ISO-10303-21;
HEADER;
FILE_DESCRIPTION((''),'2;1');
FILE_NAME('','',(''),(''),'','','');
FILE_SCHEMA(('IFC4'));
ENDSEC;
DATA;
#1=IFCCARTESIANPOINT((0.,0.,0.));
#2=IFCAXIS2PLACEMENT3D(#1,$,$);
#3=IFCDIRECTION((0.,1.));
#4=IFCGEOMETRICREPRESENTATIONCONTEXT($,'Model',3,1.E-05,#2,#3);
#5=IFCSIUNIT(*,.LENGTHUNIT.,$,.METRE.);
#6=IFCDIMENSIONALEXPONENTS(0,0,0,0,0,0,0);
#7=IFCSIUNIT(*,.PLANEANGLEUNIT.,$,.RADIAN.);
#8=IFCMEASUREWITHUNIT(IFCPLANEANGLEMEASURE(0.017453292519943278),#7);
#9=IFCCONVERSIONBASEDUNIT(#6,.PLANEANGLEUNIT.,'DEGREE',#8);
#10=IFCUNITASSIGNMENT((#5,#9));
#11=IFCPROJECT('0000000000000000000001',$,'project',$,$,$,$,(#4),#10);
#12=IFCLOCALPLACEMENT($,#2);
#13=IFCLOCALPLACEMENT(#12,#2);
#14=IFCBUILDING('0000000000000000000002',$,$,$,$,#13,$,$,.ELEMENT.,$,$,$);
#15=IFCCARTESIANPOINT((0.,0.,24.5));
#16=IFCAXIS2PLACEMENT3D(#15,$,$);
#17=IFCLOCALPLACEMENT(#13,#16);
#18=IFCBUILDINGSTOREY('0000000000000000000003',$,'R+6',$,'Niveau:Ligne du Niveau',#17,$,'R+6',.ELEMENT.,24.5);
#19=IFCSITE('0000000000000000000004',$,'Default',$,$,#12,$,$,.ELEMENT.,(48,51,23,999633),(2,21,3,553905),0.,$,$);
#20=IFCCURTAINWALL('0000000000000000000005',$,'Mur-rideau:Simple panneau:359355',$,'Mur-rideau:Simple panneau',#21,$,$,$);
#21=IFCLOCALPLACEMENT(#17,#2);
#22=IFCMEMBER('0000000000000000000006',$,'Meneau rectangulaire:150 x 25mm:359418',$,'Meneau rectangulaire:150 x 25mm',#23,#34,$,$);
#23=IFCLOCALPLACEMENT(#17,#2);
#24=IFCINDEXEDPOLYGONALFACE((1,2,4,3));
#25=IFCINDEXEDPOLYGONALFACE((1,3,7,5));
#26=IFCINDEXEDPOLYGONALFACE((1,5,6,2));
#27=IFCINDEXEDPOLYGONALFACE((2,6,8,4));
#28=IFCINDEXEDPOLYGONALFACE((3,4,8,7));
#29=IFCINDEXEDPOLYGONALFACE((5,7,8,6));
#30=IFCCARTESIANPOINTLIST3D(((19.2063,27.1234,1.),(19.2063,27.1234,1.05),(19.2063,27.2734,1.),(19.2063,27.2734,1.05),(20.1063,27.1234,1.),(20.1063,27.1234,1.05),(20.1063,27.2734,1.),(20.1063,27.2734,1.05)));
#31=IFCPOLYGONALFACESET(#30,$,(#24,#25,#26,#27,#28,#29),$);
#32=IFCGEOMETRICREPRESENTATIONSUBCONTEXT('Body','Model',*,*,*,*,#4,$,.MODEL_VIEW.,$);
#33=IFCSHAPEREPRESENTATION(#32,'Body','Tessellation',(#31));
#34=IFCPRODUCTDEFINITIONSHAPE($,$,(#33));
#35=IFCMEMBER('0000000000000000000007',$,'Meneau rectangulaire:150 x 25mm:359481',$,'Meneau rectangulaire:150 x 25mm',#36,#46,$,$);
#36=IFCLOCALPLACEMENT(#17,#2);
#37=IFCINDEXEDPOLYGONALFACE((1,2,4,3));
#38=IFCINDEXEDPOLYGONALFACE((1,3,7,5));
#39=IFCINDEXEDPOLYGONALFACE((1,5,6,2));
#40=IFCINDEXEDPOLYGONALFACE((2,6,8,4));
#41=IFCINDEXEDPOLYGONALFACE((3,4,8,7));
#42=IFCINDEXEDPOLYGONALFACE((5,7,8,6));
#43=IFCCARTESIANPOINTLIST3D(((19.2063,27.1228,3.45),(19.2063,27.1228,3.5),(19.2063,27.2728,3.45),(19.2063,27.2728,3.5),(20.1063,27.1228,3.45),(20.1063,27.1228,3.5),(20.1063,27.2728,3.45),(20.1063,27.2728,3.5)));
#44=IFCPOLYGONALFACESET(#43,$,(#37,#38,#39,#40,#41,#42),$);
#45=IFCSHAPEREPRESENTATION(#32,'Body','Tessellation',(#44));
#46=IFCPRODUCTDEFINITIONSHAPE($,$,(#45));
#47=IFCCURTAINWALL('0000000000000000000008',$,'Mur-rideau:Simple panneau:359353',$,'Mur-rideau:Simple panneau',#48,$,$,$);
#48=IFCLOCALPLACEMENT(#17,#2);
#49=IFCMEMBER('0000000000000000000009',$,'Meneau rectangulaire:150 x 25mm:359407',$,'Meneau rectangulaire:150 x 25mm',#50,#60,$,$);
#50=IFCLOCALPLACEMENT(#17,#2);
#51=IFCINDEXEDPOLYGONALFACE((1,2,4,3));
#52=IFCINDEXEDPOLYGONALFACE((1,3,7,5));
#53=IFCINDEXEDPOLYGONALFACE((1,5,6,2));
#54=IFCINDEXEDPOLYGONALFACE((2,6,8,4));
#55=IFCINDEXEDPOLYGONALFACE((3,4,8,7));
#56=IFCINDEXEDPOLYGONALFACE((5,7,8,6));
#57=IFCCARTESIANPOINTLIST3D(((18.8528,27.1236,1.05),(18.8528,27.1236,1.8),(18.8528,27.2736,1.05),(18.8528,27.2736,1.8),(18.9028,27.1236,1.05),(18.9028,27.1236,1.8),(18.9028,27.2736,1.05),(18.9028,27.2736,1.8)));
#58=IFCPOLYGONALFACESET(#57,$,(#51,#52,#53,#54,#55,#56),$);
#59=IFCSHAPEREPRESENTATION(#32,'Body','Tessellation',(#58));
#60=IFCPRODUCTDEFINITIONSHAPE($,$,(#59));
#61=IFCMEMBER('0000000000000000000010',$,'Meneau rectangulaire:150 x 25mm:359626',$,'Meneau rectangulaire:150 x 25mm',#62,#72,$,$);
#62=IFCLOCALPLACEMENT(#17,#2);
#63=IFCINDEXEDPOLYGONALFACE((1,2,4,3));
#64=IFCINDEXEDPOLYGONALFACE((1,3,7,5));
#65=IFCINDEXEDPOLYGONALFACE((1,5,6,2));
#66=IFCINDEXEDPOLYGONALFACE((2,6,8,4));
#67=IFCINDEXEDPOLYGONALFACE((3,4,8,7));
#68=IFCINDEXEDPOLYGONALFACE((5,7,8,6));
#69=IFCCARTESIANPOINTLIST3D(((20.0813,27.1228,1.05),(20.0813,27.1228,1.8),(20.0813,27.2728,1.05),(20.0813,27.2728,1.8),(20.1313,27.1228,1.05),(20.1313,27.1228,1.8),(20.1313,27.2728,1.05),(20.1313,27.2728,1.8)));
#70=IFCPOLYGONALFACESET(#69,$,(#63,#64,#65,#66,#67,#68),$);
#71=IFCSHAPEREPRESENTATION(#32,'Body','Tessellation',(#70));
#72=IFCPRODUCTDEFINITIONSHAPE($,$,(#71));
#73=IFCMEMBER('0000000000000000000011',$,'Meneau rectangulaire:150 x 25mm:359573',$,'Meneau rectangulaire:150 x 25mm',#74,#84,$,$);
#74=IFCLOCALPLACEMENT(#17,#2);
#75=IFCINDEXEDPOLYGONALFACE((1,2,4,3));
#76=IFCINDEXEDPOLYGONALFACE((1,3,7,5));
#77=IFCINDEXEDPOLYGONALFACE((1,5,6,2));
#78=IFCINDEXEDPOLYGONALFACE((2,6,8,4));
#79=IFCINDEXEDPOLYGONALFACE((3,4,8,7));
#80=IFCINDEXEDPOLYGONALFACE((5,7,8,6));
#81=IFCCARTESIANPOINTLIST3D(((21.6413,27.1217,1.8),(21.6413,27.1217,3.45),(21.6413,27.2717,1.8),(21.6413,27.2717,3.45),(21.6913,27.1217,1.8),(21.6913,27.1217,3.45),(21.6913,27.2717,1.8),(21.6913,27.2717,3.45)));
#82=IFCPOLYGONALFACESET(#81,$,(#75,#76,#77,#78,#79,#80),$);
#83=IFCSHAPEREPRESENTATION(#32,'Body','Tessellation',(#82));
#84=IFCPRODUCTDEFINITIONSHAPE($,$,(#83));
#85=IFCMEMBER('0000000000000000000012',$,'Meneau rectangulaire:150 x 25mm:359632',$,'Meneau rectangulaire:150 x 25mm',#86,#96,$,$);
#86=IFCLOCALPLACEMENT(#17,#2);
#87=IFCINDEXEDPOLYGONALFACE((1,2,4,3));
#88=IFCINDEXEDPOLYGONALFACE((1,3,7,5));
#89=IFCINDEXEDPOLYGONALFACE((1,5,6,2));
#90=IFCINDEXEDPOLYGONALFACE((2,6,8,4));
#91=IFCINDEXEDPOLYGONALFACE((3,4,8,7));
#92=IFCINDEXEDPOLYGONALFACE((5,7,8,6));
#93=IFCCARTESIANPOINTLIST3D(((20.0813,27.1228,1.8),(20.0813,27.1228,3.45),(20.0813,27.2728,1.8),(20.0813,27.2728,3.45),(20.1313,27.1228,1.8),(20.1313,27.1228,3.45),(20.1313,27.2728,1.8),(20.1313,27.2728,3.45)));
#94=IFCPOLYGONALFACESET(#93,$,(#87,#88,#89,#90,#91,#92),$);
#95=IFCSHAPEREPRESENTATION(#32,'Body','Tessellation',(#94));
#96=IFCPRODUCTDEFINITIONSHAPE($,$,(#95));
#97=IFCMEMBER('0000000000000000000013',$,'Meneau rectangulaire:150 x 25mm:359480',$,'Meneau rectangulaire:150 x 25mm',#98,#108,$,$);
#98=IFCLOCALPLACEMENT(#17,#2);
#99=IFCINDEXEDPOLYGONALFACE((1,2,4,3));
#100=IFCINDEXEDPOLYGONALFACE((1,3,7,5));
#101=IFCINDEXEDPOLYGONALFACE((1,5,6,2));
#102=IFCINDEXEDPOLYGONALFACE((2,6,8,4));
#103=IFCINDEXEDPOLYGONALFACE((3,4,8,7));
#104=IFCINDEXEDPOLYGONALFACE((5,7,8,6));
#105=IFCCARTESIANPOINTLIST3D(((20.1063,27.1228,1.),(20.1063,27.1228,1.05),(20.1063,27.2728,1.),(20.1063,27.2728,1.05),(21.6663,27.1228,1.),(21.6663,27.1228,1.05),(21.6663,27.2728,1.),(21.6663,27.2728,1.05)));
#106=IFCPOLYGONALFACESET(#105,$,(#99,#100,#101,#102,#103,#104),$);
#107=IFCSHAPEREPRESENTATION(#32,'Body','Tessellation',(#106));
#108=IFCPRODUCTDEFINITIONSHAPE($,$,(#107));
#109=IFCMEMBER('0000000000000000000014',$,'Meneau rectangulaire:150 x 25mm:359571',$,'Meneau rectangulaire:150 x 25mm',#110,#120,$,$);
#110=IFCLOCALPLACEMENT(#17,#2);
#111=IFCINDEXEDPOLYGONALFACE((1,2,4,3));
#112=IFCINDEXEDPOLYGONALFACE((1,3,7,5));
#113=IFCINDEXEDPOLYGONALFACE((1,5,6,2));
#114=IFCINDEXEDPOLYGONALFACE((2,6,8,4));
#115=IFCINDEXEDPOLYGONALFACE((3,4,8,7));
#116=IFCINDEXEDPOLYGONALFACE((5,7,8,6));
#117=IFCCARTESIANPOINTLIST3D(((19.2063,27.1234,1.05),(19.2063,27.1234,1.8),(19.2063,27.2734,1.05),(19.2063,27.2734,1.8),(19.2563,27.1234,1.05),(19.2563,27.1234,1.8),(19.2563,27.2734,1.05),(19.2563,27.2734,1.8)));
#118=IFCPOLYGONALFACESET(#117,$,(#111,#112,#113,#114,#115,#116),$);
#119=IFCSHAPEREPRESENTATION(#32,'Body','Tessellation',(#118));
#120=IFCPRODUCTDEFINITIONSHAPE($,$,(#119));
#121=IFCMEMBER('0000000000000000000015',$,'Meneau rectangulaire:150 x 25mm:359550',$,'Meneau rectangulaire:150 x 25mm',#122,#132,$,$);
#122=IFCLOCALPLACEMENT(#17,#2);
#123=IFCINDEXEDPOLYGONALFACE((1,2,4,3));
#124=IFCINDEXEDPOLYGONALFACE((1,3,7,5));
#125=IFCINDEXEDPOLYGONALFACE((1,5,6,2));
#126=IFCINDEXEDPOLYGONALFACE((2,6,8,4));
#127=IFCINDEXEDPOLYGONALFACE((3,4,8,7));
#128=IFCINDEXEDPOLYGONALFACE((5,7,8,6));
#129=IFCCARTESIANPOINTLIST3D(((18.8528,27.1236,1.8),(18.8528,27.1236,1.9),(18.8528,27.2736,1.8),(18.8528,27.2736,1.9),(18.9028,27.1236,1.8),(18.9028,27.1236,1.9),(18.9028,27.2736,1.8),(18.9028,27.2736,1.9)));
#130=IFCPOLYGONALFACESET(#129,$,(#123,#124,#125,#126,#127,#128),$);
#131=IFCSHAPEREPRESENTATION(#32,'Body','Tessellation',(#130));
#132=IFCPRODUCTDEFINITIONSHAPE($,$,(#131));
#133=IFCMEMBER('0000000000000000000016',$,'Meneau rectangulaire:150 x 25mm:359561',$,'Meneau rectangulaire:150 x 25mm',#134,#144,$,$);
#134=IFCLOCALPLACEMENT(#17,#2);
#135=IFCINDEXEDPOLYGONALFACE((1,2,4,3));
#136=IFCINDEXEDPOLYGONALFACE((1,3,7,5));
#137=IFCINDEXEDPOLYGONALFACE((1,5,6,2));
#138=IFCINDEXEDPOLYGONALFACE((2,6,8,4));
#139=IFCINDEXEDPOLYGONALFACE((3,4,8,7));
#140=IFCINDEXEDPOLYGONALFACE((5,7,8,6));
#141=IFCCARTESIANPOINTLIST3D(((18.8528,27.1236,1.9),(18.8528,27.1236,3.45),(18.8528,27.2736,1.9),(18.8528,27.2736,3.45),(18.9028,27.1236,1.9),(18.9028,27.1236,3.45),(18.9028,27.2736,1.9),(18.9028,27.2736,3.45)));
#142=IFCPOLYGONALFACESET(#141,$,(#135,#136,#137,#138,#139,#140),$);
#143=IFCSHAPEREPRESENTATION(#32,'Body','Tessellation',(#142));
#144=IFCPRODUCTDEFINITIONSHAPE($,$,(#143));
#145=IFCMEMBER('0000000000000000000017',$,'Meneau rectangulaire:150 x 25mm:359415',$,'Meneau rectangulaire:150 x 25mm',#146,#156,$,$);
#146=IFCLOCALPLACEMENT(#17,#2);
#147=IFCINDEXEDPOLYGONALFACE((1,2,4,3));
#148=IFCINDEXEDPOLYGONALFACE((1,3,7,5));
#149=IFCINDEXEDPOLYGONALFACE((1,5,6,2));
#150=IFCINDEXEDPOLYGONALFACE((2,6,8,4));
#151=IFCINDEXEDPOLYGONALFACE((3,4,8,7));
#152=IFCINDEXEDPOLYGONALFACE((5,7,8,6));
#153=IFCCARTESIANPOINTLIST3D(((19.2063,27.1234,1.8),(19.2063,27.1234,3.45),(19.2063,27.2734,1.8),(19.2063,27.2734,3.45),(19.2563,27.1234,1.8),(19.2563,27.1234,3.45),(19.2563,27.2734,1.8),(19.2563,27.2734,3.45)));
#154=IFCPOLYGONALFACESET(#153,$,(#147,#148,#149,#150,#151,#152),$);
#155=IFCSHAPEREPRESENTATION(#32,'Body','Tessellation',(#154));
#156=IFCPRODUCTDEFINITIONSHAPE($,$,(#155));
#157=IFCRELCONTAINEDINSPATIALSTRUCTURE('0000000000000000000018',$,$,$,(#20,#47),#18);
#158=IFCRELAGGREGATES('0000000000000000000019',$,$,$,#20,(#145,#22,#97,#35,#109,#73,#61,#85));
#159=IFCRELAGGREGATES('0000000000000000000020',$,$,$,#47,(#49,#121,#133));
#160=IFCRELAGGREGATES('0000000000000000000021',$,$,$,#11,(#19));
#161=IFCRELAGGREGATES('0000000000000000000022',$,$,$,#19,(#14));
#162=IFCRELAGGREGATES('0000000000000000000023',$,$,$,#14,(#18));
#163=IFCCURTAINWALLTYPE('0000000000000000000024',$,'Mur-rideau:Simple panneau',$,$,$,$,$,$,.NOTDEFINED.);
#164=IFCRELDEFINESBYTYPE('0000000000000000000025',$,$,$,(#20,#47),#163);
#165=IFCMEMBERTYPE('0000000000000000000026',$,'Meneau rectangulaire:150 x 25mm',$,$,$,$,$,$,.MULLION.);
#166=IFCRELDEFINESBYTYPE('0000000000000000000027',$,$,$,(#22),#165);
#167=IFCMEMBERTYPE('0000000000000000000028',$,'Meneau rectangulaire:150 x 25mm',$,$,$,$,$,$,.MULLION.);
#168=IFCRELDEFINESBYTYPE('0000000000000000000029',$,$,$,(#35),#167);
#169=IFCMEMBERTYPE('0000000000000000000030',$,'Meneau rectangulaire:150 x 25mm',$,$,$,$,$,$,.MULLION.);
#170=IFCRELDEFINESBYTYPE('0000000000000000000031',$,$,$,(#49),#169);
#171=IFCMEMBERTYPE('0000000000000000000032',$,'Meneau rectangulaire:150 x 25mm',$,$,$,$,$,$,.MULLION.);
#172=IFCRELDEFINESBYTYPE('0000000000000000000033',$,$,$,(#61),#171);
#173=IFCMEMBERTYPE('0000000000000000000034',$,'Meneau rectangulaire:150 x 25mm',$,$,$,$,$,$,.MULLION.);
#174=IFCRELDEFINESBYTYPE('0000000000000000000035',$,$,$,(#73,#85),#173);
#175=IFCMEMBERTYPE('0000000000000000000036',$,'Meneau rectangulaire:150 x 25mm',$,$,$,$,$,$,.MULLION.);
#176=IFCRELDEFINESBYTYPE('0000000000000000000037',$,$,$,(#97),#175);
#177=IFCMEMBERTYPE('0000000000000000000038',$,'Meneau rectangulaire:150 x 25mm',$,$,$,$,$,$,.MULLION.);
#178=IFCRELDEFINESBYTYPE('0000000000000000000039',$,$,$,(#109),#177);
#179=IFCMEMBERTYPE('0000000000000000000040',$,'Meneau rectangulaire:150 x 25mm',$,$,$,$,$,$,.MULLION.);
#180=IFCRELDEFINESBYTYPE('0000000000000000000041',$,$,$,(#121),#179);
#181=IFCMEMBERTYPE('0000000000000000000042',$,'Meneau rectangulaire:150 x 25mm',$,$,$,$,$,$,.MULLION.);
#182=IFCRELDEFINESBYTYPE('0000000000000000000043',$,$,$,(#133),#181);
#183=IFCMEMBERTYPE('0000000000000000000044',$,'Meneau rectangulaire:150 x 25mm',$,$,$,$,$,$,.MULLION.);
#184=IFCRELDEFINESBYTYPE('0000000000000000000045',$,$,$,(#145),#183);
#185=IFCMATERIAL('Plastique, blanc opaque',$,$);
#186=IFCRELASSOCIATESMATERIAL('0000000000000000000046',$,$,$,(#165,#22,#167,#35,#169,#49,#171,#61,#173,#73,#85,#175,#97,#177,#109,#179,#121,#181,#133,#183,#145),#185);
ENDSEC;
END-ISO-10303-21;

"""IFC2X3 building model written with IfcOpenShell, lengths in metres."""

from ifc_helpers import new_model, entity, si_unit, converted_unit, direction, frame, origin, origin_2d_with_axis, place, context, subcontext, project, spatial, rectangle, extrude, source, transform, mapped, material, type_object, type_shapes, element, aggregate, save


model = new_model("IFC2X3")

# Units and contexts
model_context = context("Model", 3, precision=1e-05, world=origin(), true_north=direction((0.0, 1.0)))
body_context = subcontext(model_context, "Body", "Model", "MODEL_VIEW")
ifc_project = project(units=[si_unit("LENGTHUNIT", "METRE"), converted_unit("PLANEANGLEUNIT", "DEGREE", entity("IfcPlaneAngleMeasure", 0.017453292519943278), si_unit("PLANEANGLEUNIT", "RADIAN"), dimensions=[0, 0, 0, 0, 0, 0, 0])], contexts=[model_context])

# Site, building, storey
site_placement = place(None, origin())
site = spatial("IfcSite", under=ifc_project, at=site_placement, Name="Default", CompositionType="ELEMENT", RefLatitude=(48, 51, 23, 999633), RefLongitude=(2, 21, 3, 553905), RefElevation=0.0)
building_placement = place(site_placement, origin())
building = spatial("IfcBuilding", under=site, at=building_placement, CompositionType="ELEMENT")
storey_placement = place(building_placement, frame((0.0, 0.0, 24.5)))
storey = spatial("IfcBuildingStorey", under=building, at=storey_placement, Name="R+6", ObjectType="Niveau:Ligne du Niveau", LongName="R+6", CompositionType="ELEMENT", Elevation=24.5)

# Curtain wall, members
curtain_wall_type = type_object("IfcCurtainWallType", Name="Mur-rideau:Simple panneau", PredefinedType="NOTDEFINED")
curtain_wall_1_placement = place(storey_placement, frame((0.0, 0.0, -24.5)))
curtain_wall_1 = element("IfcCurtainWall", 1, at=curtain_wall_1_placement, inside=storey, type_object=curtain_wall_type, Name="Mur-rideau:Simple panneau:359355", ObjectType="Mur-rideau:Simple panneau")
ifc_material_1 = material(Name="Plastique, blanc opaque")
member_type_1 = type_object("IfcMemberType", Name="Meneau rectangulaire:150 x 25mm", PredefinedType="MULLION", material=ifc_material_1)
shared_shape_1 = source(origin(), body_context, "Body", "SweptSolid", [
    extrude(rectangle(XDim=0.05, YDim=0.15, at=origin_2d_with_axis()), frame((-0.025, 0.0, -0.9), z_axis=(0.0, 0.0, 1.0), x_axis=(-1.0, 0.0, 0.0)), (0.0, 0.0, 1.0), 0.9),
])
type_shapes(member_type_1, [shared_shape_1])
member_1_placement = place(curtain_wall_1_placement, frame((19.2063, 27.1984, 25.5), z_axis=(-1.0, 0.0, 0.0), x_axis=(0.0, 0.0, -1.0)))
member_1 = element("IfcMember", 2, at=member_1_placement, type_object=member_type_1, material=ifc_material_1, Name="Meneau rectangulaire:150 x 25mm:359418", ObjectType="Meneau rectangulaire:150 x 25mm", context=body_context, shape_type="MappedRepresentation", body=[
    mapped(shared_shape_1, transform((0.0, 0.0, 0.0), scale=1.0)),
])
member_type_2 = type_object("IfcMemberType", Name="Meneau rectangulaire:150 x 25mm", PredefinedType="MULLION", material=ifc_material_1)
shared_shape_2 = source(origin(), body_context, "Body", "SweptSolid", [
    extrude(rectangle(XDim=0.05, YDim=0.15, at=origin_2d_with_axis()), frame((-0.025, 0.0, -0.9), z_axis=(0.0, 0.0, 1.0), x_axis=(-1.0, 0.0, 0.0)), (0.0, 0.0, 1.0), 0.9),
])
type_shapes(member_type_2, [shared_shape_2])
member_2_placement = place(curtain_wall_1_placement, frame((20.1063, 27.1978, 28.0), z_axis=(1.0, 0.0, 0.0), x_axis=(0.0, 0.0, 1.0)))
member_2 = element("IfcMember", 3, at=member_2_placement, type_object=member_type_2, material=ifc_material_1, Name="Meneau rectangulaire:150 x 25mm:359481", ObjectType="Meneau rectangulaire:150 x 25mm", context=body_context, shape_type="MappedRepresentation", body=[
    mapped(shared_shape_2, transform((0.0, 0.0, 0.0), scale=1.0)),
])

# Curtain wall, member
curtain_wall_2_placement = place(storey_placement, frame((0.0, 0.0, -24.5)))
curtain_wall_2 = element("IfcCurtainWall", 4, at=curtain_wall_2_placement, inside=storey, type_object=curtain_wall_type, Name="Mur-rideau:Simple panneau:359353", ObjectType="Mur-rideau:Simple panneau")
member_type_3 = type_object("IfcMemberType", Name="Meneau rectangulaire:150 x 25mm", PredefinedType="MULLION", material=ifc_material_1)
shared_shape_3 = source(origin(), body_context, "Body", "SweptSolid", [
    extrude(rectangle(XDim=0.05, YDim=0.15, at=origin_2d_with_axis()), frame((-0.025, 0.0, -0.75), z_axis=(0.0, 0.0, 1.0), x_axis=(-1.0, 0.0, 0.0)), (0.0, 0.0, 1.0), 0.75),
])
type_shapes(member_type_3, [shared_shape_3])
member_3_placement = place(curtain_wall_2_placement, frame((18.9028, 27.1986, 25.55), z_axis=(0.0, 0.0, -1.0), x_axis=(1.0, 0.0, 0.0)))
member_3 = element("IfcMember", 5, at=member_3_placement, type_object=member_type_3, material=ifc_material_1, Name="Meneau rectangulaire:150 x 25mm:359407", ObjectType="Meneau rectangulaire:150 x 25mm", context=body_context, shape_type="MappedRepresentation", body=[
    mapped(shared_shape_3, transform((0.0, 0.0, 0.0), scale=1.0)),
])

# Members
member_type_4 = type_object("IfcMemberType", Name="Meneau rectangulaire:150 x 25mm", PredefinedType="MULLION", material=ifc_material_1)
shared_shape_4 = source(origin(), body_context, "Body", "SweptSolid", [
    extrude(rectangle(XDim=0.05, YDim=0.15, at=origin_2d_with_axis()), frame((0.0, 0.0, -0.75), z_axis=(0.0, 0.0, 1.0), x_axis=(-1.0, 0.0, 0.0)), (0.0, 0.0, 1.0), 0.75),
])
type_shapes(member_type_4, [shared_shape_4])
member_4_placement = place(curtain_wall_1_placement, frame((20.1063, 27.1978, 25.55), z_axis=(0.0, 0.0, -1.0), x_axis=(1.0, 0.0, 0.0)))
member_4 = element("IfcMember", 6, at=member_4_placement, type_object=member_type_4, material=ifc_material_1, Name="Meneau rectangulaire:150 x 25mm:359626", ObjectType="Meneau rectangulaire:150 x 25mm", context=body_context, shape_type="MappedRepresentation", body=[
    mapped(shared_shape_4, transform((0.0, 0.0, 0.0), scale=1.0)),
])
member_type_5 = type_object("IfcMemberType", Name="Meneau rectangulaire:150 x 25mm", PredefinedType="MULLION", material=ifc_material_1)
shared_shape_5 = source(origin(), body_context, "Body", "SweptSolid", [
    extrude(rectangle(XDim=0.05, YDim=0.15, at=origin_2d_with_axis()), frame((0.0, 0.0, -1.65), z_axis=(0.0, 0.0, 1.0), x_axis=(-1.0, 0.0, 0.0)), (0.0, 0.0, 1.0), 1.65),
])
type_shapes(member_type_5, [shared_shape_5])
member_5_placement = place(curtain_wall_1_placement, frame((21.6663, 27.1967, 26.3), z_axis=(0.0, 0.0, -1.0), x_axis=(1.0, 0.0, 0.0)))
member_5 = element("IfcMember", 7, at=member_5_placement, type_object=member_type_5, material=ifc_material_1, Name="Meneau rectangulaire:150 x 25mm:359573", ObjectType="Meneau rectangulaire:150 x 25mm", context=body_context, shape_type="MappedRepresentation", body=[
    mapped(shared_shape_5, transform((0.0, 0.0, 0.0), scale=1.0)),
])
member_6_placement = place(curtain_wall_1_placement, frame((20.1063, 27.1978, 26.3), z_axis=(0.0, 0.0, -1.0), x_axis=(1.0, 0.0, 0.0)))
member_6 = element("IfcMember", 8, at=member_6_placement, type_object=member_type_5, material=ifc_material_1, Name="Meneau rectangulaire:150 x 25mm:359632", ObjectType="Meneau rectangulaire:150 x 25mm", context=body_context, shape_type="MappedRepresentation", body=[
    mapped(shared_shape_5, transform((0.0, 0.0, 0.0), scale=1.0)),
])
member_type_6 = type_object("IfcMemberType", Name="Meneau rectangulaire:150 x 25mm", PredefinedType="MULLION", material=ifc_material_1)
shared_shape_6 = source(origin(), body_context, "Body", "SweptSolid", [
    extrude(rectangle(XDim=0.05, YDim=0.15, at=origin_2d_with_axis()), frame((-0.025, 0.0, -1.56), z_axis=(0.0, 0.0, 1.0), x_axis=(-1.0, 0.0, 0.0)), (0.0, 0.0, 1.0), 1.56),
])
type_shapes(member_type_6, [shared_shape_6])
member_7_placement = place(curtain_wall_1_placement, frame((20.1063, 27.1978, 25.5), z_axis=(-1.0, 0.0, 0.0), x_axis=(0.0, 0.0, -1.0)))
member_7 = element("IfcMember", 9, at=member_7_placement, type_object=member_type_6, material=ifc_material_1, Name="Meneau rectangulaire:150 x 25mm:359480", ObjectType="Meneau rectangulaire:150 x 25mm", context=body_context, shape_type="MappedRepresentation", body=[
    mapped(shared_shape_6, transform((0.0, 0.0, 0.0), scale=1.0)),
])
member_type_7 = type_object("IfcMemberType", Name="Meneau rectangulaire:150 x 25mm", PredefinedType="MULLION", material=ifc_material_1)
shared_shape_7 = source(origin(), body_context, "Body", "SweptSolid", [
    extrude(rectangle(XDim=0.05, YDim=0.15, at=origin_2d_with_axis()), frame((-0.025, 0.0, -0.75), z_axis=(0.0, 0.0, 1.0), x_axis=(-1.0, 0.0, 0.0)), (0.0, 0.0, 1.0), 0.75),
])
type_shapes(member_type_7, [shared_shape_7])
member_8_placement = place(curtain_wall_1_placement, frame((19.2063, 27.1984, 26.3), z_axis=(0.0, 0.0, 1.0), x_axis=(-1.0, 0.0, 0.0)))
member_8 = element("IfcMember", 10, at=member_8_placement, type_object=member_type_7, material=ifc_material_1, Name="Meneau rectangulaire:150 x 25mm:359571", ObjectType="Meneau rectangulaire:150 x 25mm", context=body_context, shape_type="MappedRepresentation", body=[
    mapped(shared_shape_7, transform((0.0, 0.0, 0.0), scale=1.0)),
])
member_type_8 = type_object("IfcMemberType", Name="Meneau rectangulaire:150 x 25mm", PredefinedType="MULLION", material=ifc_material_1)
shared_shape_8 = source(origin(), body_context, "Body", "SweptSolid", [
    extrude(rectangle(XDim=0.05, YDim=0.15, at=origin_2d_with_axis()), frame((-0.025, 0.0, -0.1), z_axis=(0.0, 0.0, 1.0), x_axis=(-1.0, 0.0, 0.0)), (0.0, 0.0, 1.0), 0.1),
])
type_shapes(member_type_8, [shared_shape_8])
member_9_placement = place(curtain_wall_2_placement, frame((18.9028, 27.1986, 26.3), z_axis=(0.0, 0.0, -1.0), x_axis=(1.0, 0.0, 0.0)))
member_9 = element("IfcMember", 11, at=member_9_placement, type_object=member_type_8, material=ifc_material_1, Name="Meneau rectangulaire:150 x 25mm:359550", ObjectType="Meneau rectangulaire:150 x 25mm", context=body_context, shape_type="MappedRepresentation", body=[
    mapped(shared_shape_8, transform((0.0, 0.0, 0.0), scale=1.0)),
])
member_type_9 = type_object("IfcMemberType", Name="Meneau rectangulaire:150 x 25mm", PredefinedType="MULLION", material=ifc_material_1)
shared_shape_9 = source(origin(), body_context, "Body", "SweptSolid", [
    extrude(rectangle(XDim=0.05, YDim=0.15, at=origin_2d_with_axis()), frame((-0.025, 0.0, -1.55), z_axis=(0.0, 0.0, 1.0), x_axis=(-1.0, 0.0, 0.0)), (0.0, 0.0, 1.0), 1.55),
])
type_shapes(member_type_9, [shared_shape_9])
member_10_placement = place(curtain_wall_2_placement, frame((18.9028, 27.1986, 26.4), z_axis=(0.0, 0.0, -1.0), x_axis=(1.0, 0.0, 0.0)))
member_10 = element("IfcMember", 12, at=member_10_placement, type_object=member_type_9, material=ifc_material_1, Name="Meneau rectangulaire:150 x 25mm:359561", ObjectType="Meneau rectangulaire:150 x 25mm", context=body_context, shape_type="MappedRepresentation", body=[
    mapped(shared_shape_9, transform((0.0, 0.0, 0.0), scale=1.0)),
])
member_type_10 = type_object("IfcMemberType", Name="Meneau rectangulaire:150 x 25mm", PredefinedType="MULLION", material=ifc_material_1)
shared_shape_10 = source(origin(), body_context, "Body", "SweptSolid", [
    extrude(rectangle(XDim=0.05, YDim=0.15, at=origin_2d_with_axis()), frame((-0.025, 0.0, -1.65), z_axis=(0.0, 0.0, 1.0), x_axis=(-1.0, 0.0, 0.0)), (0.0, 0.0, 1.0), 1.65),
])
type_shapes(member_type_10, [shared_shape_10])
member_11_placement = place(curtain_wall_1_placement, frame((19.2063, 27.1984, 27.95), z_axis=(0.0, 0.0, 1.0), x_axis=(-1.0, 0.0, 0.0)))
member_11 = element("IfcMember", 13, at=member_11_placement, type_object=member_type_10, material=ifc_material_1, Name="Meneau rectangulaire:150 x 25mm:359415", ObjectType="Meneau rectangulaire:150 x 25mm", context=body_context, shape_type="MappedRepresentation", body=[
    mapped(shared_shape_10, transform((0.0, 0.0, 0.0), scale=1.0)),
])

aggregate(curtain_wall_1, [member_11, member_1, member_7, member_2, member_8, member_5, member_4, member_6])
aggregate(curtain_wall_2, [member_3, member_9, member_10])

save(model, "model.ifc")
